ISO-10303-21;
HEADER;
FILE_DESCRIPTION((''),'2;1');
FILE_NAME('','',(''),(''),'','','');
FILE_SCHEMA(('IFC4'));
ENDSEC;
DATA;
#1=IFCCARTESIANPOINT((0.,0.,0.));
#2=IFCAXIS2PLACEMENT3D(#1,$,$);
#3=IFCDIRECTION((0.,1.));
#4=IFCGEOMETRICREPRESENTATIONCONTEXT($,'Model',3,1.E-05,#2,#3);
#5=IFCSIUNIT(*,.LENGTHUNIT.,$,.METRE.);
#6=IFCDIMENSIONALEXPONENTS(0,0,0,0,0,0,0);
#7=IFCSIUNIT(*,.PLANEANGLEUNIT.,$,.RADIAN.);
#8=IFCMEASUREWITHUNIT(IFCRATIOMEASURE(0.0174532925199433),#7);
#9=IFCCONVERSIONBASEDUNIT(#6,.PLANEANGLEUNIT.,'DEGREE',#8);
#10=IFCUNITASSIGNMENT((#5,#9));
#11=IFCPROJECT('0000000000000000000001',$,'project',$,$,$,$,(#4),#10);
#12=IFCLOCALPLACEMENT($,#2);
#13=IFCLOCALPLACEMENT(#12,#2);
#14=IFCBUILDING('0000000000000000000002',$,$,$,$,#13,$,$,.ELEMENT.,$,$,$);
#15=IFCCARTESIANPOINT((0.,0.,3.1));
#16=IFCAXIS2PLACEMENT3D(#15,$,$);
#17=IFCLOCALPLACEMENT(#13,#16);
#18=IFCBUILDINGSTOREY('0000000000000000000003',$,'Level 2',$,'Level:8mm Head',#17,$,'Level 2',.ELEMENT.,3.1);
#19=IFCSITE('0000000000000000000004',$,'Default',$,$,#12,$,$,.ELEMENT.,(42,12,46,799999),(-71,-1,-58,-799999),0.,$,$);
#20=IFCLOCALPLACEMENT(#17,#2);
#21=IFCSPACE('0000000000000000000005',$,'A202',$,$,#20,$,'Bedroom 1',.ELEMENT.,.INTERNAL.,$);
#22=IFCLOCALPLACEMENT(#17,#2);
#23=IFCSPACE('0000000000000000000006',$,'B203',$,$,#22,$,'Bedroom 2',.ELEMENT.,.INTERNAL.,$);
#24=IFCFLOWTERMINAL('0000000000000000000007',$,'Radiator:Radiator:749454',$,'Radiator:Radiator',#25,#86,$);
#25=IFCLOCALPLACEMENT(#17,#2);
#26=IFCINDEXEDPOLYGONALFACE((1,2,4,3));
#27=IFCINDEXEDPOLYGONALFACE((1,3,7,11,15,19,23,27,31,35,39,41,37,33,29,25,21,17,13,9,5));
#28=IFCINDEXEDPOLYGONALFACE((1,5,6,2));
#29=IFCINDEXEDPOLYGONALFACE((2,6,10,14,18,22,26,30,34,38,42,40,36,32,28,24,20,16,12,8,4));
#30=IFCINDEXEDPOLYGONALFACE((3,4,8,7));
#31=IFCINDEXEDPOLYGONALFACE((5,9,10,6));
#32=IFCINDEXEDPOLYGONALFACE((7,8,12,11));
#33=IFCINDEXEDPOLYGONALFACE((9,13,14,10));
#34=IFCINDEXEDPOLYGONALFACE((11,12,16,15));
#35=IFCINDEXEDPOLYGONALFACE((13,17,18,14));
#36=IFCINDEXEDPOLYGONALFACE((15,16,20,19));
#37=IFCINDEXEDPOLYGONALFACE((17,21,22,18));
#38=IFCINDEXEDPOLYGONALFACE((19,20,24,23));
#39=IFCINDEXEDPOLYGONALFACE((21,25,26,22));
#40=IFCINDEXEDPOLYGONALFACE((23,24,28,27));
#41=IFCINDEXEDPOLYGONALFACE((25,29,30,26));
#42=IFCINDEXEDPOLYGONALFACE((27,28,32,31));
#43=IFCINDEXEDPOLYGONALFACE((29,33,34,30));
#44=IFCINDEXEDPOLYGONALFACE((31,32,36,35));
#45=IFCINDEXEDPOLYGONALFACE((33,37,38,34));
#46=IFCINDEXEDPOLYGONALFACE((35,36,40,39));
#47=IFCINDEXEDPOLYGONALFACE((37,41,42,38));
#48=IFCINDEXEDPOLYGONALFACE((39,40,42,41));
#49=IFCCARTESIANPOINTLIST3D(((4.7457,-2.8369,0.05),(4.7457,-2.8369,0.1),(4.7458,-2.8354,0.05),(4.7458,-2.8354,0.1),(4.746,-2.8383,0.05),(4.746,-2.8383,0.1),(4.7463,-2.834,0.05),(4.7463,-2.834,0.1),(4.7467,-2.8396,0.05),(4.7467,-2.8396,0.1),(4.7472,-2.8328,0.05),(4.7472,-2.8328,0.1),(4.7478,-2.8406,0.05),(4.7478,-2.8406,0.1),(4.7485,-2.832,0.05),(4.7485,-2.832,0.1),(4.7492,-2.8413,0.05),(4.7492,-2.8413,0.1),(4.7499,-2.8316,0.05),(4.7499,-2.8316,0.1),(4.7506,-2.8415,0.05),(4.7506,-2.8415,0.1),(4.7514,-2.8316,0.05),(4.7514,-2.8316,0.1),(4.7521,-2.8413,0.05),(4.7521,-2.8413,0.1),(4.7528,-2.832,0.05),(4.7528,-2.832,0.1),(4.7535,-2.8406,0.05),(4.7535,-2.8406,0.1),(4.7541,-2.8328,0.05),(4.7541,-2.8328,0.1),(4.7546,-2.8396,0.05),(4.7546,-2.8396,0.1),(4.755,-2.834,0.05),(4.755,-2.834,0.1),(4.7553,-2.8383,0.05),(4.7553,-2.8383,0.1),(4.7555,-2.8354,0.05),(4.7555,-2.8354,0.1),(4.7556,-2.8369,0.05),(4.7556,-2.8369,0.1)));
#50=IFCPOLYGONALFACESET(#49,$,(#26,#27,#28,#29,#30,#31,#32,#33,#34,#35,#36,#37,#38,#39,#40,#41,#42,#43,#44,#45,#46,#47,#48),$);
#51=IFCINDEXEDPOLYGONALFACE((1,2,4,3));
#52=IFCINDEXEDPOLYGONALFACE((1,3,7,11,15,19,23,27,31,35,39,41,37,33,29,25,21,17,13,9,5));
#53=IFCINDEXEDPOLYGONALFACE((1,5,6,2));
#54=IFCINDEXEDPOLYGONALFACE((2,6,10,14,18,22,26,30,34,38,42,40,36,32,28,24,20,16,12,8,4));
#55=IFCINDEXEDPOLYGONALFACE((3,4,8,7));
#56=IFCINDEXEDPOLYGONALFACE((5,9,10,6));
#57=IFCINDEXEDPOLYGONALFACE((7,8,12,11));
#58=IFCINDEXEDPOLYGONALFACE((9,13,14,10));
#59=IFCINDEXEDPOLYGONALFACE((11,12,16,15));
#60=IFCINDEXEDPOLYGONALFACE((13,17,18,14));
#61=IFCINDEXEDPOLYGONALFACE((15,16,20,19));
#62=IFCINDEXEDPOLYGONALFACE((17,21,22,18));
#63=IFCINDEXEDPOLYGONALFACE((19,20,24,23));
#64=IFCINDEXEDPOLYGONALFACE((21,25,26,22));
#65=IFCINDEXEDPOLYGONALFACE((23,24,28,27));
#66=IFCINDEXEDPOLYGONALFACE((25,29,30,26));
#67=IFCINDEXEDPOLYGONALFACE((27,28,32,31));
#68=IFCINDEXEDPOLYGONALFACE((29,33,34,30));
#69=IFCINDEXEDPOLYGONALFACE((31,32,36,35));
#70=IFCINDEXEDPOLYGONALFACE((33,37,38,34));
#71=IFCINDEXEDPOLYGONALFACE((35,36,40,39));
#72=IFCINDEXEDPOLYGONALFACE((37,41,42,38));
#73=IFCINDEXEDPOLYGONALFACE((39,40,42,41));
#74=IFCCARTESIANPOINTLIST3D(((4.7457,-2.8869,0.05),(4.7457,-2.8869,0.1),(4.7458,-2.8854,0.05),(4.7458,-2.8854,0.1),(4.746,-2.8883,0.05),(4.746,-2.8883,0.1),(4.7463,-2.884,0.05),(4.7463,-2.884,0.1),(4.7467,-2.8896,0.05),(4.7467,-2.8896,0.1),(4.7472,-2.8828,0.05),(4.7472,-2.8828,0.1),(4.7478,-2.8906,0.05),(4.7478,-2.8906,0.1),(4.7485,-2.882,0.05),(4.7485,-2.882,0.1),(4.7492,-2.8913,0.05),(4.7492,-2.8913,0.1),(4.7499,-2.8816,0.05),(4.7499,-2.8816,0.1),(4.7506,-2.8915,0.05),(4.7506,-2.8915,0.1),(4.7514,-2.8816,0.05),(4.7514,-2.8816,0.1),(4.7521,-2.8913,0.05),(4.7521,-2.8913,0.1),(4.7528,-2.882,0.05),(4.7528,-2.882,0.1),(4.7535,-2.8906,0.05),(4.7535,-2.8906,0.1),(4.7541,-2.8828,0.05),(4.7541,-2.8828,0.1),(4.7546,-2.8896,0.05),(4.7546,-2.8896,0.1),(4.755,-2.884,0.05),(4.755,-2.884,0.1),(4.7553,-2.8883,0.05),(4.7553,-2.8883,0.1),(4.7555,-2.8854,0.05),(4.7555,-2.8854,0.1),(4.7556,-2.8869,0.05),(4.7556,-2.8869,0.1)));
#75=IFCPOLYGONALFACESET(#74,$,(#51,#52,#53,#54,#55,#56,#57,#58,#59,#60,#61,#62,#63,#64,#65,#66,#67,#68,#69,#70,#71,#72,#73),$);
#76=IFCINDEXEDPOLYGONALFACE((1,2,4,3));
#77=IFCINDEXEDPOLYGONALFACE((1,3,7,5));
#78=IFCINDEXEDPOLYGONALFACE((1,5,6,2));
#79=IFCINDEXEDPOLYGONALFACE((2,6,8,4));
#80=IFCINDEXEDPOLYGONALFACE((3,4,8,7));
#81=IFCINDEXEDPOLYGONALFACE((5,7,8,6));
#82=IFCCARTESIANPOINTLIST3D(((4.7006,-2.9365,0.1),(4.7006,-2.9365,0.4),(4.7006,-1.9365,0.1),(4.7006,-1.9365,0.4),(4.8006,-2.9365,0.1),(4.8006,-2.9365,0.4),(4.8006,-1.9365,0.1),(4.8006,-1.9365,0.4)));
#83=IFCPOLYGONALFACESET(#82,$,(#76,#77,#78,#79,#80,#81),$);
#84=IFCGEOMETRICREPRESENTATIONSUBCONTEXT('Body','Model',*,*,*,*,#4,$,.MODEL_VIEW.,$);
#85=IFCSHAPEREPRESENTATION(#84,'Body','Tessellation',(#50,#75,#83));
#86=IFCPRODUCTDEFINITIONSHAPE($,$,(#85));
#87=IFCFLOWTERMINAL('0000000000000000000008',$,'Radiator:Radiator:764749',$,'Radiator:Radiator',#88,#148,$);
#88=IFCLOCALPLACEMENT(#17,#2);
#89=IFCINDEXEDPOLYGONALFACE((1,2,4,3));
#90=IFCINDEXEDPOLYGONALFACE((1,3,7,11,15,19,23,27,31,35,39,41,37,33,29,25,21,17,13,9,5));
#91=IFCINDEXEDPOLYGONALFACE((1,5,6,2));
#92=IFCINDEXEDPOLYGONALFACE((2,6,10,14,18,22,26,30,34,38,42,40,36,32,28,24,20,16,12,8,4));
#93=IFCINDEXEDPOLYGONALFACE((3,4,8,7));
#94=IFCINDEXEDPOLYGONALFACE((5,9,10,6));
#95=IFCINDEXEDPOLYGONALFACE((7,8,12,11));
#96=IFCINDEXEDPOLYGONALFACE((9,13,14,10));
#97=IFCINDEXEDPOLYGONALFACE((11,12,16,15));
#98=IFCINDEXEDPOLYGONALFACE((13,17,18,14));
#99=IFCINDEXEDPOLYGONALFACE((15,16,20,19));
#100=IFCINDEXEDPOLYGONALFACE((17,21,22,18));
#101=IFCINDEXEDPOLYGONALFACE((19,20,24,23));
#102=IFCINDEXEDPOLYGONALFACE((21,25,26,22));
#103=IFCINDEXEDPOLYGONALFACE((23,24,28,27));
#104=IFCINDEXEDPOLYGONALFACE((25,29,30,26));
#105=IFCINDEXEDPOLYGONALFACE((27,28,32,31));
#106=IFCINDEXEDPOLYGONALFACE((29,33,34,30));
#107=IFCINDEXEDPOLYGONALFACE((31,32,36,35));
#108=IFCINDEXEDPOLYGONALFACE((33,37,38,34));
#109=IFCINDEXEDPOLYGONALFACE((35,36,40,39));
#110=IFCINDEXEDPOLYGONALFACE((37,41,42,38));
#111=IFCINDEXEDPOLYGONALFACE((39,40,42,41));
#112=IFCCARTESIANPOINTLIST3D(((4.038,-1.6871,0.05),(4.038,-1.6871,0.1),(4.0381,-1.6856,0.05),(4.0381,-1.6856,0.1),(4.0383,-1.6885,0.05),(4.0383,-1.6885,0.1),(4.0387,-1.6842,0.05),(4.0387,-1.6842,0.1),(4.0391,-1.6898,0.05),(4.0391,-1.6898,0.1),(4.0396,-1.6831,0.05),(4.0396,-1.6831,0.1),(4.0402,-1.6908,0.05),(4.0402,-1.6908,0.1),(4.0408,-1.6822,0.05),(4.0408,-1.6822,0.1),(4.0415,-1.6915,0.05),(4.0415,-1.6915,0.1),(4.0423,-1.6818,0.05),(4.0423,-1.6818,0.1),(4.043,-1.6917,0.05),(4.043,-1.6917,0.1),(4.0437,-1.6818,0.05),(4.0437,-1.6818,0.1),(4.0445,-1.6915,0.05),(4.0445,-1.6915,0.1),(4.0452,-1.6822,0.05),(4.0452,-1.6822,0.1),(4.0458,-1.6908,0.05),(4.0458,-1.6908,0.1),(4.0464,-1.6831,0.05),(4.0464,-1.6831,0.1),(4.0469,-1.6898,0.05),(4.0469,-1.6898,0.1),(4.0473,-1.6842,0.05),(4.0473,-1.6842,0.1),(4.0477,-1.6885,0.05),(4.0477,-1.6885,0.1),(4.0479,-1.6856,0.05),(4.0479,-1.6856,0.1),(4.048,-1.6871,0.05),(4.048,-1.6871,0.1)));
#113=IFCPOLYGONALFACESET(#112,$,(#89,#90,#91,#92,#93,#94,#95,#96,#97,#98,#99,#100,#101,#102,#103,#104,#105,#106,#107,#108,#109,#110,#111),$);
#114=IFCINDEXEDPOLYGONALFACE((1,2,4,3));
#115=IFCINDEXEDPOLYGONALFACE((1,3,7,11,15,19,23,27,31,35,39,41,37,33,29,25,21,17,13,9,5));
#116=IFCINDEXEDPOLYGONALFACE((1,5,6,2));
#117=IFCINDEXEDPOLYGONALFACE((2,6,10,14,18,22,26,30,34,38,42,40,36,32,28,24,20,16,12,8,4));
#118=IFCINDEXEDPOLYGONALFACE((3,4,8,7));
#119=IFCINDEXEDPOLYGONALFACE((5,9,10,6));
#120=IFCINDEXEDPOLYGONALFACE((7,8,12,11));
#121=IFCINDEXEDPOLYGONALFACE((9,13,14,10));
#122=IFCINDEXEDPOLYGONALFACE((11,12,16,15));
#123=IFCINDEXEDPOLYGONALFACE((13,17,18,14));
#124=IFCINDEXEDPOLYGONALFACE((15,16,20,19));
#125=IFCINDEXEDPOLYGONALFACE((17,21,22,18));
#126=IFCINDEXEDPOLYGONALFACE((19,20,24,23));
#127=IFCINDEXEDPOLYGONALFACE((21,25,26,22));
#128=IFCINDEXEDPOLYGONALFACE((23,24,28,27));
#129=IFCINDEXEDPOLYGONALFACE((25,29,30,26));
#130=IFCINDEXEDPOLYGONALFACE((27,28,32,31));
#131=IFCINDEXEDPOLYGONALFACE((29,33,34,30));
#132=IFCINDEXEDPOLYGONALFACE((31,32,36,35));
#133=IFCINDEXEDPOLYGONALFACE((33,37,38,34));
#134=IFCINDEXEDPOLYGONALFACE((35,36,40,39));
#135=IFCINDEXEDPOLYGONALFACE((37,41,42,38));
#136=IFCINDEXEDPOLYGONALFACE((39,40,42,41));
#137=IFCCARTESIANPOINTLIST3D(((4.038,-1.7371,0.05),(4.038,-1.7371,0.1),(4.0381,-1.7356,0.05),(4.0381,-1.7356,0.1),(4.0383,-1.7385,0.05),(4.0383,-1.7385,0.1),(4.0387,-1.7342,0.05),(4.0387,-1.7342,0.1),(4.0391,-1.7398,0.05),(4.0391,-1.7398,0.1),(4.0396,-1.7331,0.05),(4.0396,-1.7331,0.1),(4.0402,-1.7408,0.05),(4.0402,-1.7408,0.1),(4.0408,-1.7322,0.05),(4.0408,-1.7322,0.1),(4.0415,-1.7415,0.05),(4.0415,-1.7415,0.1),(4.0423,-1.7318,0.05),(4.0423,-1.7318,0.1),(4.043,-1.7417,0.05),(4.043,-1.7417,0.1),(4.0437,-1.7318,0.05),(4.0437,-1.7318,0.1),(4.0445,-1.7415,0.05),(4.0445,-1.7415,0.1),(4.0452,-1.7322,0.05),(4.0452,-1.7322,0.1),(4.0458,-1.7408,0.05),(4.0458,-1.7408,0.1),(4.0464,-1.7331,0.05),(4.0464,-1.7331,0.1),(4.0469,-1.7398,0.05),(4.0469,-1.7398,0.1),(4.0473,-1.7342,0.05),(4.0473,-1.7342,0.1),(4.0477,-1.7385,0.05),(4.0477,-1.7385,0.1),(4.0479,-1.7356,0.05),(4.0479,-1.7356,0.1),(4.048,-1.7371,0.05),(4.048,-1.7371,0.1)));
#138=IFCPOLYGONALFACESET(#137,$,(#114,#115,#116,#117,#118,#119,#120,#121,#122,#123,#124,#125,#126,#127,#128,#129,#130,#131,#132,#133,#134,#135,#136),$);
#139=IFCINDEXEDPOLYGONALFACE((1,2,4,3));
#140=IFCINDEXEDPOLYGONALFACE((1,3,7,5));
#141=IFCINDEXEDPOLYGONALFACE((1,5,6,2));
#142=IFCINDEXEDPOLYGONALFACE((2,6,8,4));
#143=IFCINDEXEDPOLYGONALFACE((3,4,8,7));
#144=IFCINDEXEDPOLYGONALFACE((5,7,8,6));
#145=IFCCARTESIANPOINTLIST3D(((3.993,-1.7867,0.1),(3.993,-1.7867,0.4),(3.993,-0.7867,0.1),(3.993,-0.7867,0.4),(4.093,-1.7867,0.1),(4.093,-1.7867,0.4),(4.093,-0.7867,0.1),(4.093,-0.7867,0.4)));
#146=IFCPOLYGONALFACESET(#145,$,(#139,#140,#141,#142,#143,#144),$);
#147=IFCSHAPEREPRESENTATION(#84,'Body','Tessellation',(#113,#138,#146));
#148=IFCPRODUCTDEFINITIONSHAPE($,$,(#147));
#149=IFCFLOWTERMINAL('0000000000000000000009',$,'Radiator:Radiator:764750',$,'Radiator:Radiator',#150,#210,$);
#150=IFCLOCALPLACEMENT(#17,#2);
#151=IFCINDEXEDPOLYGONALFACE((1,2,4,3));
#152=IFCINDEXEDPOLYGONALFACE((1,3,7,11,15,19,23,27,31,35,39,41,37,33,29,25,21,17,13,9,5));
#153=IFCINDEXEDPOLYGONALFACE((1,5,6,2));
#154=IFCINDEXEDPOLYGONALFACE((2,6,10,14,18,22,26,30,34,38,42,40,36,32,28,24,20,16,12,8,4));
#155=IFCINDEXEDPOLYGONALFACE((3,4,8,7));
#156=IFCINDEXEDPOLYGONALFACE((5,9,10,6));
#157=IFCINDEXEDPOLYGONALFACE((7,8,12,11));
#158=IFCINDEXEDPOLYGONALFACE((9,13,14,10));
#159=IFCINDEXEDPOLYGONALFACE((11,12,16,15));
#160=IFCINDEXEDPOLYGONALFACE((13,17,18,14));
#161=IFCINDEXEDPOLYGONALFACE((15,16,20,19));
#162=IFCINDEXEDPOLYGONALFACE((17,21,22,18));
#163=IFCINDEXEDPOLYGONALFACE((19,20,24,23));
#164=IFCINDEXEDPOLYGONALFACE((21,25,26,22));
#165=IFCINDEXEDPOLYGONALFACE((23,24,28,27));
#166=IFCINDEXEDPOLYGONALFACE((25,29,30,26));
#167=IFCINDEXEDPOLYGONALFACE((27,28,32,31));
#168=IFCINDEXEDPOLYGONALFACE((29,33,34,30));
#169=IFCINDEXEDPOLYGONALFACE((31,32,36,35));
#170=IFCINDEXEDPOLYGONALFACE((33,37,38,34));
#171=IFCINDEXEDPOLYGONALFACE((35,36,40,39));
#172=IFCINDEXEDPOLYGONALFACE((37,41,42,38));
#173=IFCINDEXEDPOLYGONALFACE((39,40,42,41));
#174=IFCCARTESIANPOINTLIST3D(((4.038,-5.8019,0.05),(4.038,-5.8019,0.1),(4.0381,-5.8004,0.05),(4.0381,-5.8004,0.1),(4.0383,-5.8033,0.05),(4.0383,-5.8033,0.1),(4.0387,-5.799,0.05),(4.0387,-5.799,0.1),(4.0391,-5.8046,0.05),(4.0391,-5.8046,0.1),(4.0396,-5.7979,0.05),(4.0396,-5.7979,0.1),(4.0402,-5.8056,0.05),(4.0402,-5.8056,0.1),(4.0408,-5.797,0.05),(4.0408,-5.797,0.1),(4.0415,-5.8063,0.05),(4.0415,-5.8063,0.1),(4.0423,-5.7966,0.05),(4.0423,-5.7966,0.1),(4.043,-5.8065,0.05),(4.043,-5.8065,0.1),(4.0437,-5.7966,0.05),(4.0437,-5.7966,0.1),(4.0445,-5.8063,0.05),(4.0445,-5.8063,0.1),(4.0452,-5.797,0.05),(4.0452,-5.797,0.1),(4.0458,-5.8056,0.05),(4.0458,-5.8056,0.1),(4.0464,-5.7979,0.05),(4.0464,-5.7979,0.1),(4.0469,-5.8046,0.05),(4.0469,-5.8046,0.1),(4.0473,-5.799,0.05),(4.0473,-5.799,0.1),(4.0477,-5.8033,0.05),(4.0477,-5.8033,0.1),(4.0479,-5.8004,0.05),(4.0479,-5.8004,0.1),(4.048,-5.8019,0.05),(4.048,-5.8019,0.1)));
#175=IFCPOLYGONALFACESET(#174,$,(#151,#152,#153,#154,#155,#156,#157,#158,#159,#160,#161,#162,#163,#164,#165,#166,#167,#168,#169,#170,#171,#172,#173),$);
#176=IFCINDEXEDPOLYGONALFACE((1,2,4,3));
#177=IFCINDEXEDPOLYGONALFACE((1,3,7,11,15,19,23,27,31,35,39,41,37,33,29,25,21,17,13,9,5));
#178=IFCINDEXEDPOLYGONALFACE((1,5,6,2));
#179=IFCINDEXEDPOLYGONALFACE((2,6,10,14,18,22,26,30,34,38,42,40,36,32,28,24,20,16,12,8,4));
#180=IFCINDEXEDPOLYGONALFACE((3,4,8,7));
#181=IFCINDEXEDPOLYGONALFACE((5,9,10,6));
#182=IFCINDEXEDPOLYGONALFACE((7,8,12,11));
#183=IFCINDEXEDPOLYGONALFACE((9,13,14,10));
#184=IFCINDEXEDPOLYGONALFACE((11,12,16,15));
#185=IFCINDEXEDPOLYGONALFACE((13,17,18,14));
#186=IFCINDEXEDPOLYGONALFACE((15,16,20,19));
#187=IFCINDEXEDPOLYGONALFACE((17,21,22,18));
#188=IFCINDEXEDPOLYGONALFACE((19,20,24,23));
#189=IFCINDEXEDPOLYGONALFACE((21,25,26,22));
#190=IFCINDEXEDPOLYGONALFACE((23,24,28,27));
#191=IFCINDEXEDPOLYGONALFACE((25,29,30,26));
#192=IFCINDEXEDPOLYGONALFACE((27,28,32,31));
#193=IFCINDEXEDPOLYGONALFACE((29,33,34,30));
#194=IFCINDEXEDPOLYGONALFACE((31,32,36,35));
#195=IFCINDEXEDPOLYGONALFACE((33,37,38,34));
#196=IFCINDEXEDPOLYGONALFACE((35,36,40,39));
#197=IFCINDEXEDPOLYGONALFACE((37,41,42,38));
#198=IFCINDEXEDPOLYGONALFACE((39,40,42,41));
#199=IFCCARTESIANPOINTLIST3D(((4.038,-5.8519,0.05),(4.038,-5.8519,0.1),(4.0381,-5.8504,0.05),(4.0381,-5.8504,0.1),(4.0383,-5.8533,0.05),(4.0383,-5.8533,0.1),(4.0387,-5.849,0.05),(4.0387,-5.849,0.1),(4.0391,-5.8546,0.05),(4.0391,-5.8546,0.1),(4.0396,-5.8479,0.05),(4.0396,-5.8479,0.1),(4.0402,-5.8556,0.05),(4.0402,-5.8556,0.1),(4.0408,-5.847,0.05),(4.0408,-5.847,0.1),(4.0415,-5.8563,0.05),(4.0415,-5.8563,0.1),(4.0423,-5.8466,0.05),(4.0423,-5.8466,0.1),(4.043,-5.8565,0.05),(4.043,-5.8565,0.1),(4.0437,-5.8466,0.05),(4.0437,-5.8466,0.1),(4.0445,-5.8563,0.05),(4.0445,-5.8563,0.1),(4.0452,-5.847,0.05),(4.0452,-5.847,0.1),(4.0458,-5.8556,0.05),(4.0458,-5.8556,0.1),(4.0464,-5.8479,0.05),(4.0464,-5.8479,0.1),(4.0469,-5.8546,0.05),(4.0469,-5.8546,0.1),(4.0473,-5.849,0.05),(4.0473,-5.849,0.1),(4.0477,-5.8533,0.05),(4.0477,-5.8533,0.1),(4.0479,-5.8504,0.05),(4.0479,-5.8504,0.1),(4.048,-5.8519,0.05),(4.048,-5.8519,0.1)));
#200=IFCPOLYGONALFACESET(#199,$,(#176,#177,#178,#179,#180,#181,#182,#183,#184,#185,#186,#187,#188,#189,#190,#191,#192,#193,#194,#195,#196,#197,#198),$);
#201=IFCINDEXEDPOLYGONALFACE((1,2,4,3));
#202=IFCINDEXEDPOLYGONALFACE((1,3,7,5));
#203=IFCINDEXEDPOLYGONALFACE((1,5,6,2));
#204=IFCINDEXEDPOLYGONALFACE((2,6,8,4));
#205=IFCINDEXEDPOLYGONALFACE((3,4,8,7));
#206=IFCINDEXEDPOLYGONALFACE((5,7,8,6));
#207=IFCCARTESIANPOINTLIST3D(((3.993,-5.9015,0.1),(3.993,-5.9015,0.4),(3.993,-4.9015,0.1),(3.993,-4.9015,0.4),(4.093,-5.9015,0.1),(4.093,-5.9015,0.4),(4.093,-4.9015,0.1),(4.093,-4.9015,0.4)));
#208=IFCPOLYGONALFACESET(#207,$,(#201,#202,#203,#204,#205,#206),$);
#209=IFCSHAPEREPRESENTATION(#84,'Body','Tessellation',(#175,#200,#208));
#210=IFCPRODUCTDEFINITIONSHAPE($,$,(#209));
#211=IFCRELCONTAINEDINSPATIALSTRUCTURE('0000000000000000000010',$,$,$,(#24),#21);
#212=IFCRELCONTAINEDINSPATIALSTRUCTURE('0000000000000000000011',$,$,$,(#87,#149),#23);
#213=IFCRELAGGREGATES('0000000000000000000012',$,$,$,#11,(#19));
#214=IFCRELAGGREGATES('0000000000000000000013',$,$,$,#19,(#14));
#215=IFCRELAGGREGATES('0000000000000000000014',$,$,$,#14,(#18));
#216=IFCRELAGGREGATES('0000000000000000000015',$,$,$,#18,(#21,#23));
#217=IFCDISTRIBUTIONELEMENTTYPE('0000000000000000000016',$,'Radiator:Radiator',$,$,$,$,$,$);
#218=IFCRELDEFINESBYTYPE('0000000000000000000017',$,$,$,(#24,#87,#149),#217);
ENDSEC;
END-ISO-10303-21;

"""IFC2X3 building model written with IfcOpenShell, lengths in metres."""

from ifc_helpers import new_model, entity, si_unit, converted_unit, direction, frame, frame_2d, origin, origin_2d_with_axis, place, context, subcontext, project, spatial, rectangle, circle, extrude, source, transform, mapped, type_object, type_shapes, element, save


model = new_model("IFC2X3")

# Units and contexts
model_context = context("Model", 3, precision=1e-05, world=origin(), true_north=direction((0.0, 1.0)))
body_context = subcontext(model_context, "Body", "Model", "MODEL_VIEW")
ifc_project = project(units=[si_unit("LENGTHUNIT", "METRE"), converted_unit("PLANEANGLEUNIT", "DEGREE", entity("IfcRatioMeasure", 0.0174532925199433), si_unit("PLANEANGLEUNIT", "RADIAN"), dimensions=[0, 0, 0, 0, 0, 0, 0])], contexts=[model_context])

# Site, building, storey
site_placement = place(None, origin())
site = spatial("IfcSite", under=ifc_project, at=site_placement, Name="Default", CompositionType="ELEMENT", RefLatitude=(42, 12, 46, 799999), RefLongitude=(-71, -1, -58, -799999), RefElevation=0.0)
building_placement = place(site_placement, origin())
building = spatial("IfcBuilding", under=site, at=building_placement, CompositionType="ELEMENT")
storey_placement = place(building_placement, frame((0.0, 0.0, 3.1)))
storey = spatial("IfcBuildingStorey", under=building, at=storey_placement, Name="Level 2", ObjectType="Level:8mm Head", LongName="Level 2", CompositionType="ELEMENT", Elevation=3.1)

# Shared definitions
distribution_element_type = type_object("IfcDistributionElementType", Name="Radiator:Radiator")
shared_shape = source(origin(), body_context, "Body", "SweptSolid", [
    extrude(circle(Radius=0.005, at=frame_2d((0.0, 0.0), x_axis=(1.0, 0.0))), frame((0.4, 0.0, -0.05)), (0.0, 0.0, 1.0), 0.05),
    extrude(circle(Radius=0.005, at=frame_2d((0.0, 0.0), x_axis=(1.0, 0.0))), frame((0.45, 0.0, -0.05)), (0.0, 0.0, 1.0), 0.05),
    extrude(rectangle(XDim=1.0, YDim=0.1, at=origin_2d_with_axis()), frame((0.0, 0.0, 0.0), z_axis=(0.0, 0.0, 1.0), x_axis=(-1.0, 0.0, 0.0)), (0.0, 0.0, 1.0), 0.3),
])
type_shapes(distribution_element_type, [shared_shape])

# Shared definitions
space_1_placement = place(storey_placement, origin())
space_1 = spatial("IfcSpace", under=storey, at=space_1_placement, Name="A202", LongName="Bedroom 1", CompositionType="ELEMENT", InteriorOrExteriorSpace="INTERNAL")

# Flow terminal
flow_terminal_1_placement = place(space_1_placement, frame((4.7506, -2.4365, 0.1), z_axis=(0.0, 0.0, 1.0), x_axis=(0.0, -1.0, 0.0)))
element("IfcFlowTerminal", 1, at=flow_terminal_1_placement, inside=space_1, type_object=distribution_element_type, Name="Radiator:Radiator:749454", ObjectType="Radiator:Radiator", context=body_context, shape_type="MappedRepresentation", body=[
    mapped(shared_shape, transform((0.0, 0.0, 0.0), scale=1.0)),
])

# Shared definitions
space_2_placement = place(storey_placement, origin())
space_2 = spatial("IfcSpace", under=storey, at=space_2_placement, Name="B203", LongName="Bedroom 2", CompositionType="ELEMENT", InteriorOrExteriorSpace="INTERNAL")

# Flow terminals
for number, where, z_axis, x_axis, name in (
    (2, (4.043, -1.2867, 0.1), (0.0, 0.0, 1.0), (0.0, -1.0, 0.0), "Radiator:Radiator:764749"),
    (3, (4.043, -5.4015, 0.1), (0.0, 0.0, 1.0), (0.0, -1.0, 0.0), "Radiator:Radiator:764750"),
):
    element("IfcFlowTerminal", number, at=place(space_2_placement, frame(where, z_axis=z_axis, x_axis=x_axis)), inside=space_2, type_object=distribution_element_type, Name=name, ObjectType="Radiator:Radiator", context=body_context, shape_type="MappedRepresentation", body=[
        mapped(shared_shape, transform((0.0, 0.0, 0.0), scale=1.0)),
    ])

save(model, "model.ifc")
